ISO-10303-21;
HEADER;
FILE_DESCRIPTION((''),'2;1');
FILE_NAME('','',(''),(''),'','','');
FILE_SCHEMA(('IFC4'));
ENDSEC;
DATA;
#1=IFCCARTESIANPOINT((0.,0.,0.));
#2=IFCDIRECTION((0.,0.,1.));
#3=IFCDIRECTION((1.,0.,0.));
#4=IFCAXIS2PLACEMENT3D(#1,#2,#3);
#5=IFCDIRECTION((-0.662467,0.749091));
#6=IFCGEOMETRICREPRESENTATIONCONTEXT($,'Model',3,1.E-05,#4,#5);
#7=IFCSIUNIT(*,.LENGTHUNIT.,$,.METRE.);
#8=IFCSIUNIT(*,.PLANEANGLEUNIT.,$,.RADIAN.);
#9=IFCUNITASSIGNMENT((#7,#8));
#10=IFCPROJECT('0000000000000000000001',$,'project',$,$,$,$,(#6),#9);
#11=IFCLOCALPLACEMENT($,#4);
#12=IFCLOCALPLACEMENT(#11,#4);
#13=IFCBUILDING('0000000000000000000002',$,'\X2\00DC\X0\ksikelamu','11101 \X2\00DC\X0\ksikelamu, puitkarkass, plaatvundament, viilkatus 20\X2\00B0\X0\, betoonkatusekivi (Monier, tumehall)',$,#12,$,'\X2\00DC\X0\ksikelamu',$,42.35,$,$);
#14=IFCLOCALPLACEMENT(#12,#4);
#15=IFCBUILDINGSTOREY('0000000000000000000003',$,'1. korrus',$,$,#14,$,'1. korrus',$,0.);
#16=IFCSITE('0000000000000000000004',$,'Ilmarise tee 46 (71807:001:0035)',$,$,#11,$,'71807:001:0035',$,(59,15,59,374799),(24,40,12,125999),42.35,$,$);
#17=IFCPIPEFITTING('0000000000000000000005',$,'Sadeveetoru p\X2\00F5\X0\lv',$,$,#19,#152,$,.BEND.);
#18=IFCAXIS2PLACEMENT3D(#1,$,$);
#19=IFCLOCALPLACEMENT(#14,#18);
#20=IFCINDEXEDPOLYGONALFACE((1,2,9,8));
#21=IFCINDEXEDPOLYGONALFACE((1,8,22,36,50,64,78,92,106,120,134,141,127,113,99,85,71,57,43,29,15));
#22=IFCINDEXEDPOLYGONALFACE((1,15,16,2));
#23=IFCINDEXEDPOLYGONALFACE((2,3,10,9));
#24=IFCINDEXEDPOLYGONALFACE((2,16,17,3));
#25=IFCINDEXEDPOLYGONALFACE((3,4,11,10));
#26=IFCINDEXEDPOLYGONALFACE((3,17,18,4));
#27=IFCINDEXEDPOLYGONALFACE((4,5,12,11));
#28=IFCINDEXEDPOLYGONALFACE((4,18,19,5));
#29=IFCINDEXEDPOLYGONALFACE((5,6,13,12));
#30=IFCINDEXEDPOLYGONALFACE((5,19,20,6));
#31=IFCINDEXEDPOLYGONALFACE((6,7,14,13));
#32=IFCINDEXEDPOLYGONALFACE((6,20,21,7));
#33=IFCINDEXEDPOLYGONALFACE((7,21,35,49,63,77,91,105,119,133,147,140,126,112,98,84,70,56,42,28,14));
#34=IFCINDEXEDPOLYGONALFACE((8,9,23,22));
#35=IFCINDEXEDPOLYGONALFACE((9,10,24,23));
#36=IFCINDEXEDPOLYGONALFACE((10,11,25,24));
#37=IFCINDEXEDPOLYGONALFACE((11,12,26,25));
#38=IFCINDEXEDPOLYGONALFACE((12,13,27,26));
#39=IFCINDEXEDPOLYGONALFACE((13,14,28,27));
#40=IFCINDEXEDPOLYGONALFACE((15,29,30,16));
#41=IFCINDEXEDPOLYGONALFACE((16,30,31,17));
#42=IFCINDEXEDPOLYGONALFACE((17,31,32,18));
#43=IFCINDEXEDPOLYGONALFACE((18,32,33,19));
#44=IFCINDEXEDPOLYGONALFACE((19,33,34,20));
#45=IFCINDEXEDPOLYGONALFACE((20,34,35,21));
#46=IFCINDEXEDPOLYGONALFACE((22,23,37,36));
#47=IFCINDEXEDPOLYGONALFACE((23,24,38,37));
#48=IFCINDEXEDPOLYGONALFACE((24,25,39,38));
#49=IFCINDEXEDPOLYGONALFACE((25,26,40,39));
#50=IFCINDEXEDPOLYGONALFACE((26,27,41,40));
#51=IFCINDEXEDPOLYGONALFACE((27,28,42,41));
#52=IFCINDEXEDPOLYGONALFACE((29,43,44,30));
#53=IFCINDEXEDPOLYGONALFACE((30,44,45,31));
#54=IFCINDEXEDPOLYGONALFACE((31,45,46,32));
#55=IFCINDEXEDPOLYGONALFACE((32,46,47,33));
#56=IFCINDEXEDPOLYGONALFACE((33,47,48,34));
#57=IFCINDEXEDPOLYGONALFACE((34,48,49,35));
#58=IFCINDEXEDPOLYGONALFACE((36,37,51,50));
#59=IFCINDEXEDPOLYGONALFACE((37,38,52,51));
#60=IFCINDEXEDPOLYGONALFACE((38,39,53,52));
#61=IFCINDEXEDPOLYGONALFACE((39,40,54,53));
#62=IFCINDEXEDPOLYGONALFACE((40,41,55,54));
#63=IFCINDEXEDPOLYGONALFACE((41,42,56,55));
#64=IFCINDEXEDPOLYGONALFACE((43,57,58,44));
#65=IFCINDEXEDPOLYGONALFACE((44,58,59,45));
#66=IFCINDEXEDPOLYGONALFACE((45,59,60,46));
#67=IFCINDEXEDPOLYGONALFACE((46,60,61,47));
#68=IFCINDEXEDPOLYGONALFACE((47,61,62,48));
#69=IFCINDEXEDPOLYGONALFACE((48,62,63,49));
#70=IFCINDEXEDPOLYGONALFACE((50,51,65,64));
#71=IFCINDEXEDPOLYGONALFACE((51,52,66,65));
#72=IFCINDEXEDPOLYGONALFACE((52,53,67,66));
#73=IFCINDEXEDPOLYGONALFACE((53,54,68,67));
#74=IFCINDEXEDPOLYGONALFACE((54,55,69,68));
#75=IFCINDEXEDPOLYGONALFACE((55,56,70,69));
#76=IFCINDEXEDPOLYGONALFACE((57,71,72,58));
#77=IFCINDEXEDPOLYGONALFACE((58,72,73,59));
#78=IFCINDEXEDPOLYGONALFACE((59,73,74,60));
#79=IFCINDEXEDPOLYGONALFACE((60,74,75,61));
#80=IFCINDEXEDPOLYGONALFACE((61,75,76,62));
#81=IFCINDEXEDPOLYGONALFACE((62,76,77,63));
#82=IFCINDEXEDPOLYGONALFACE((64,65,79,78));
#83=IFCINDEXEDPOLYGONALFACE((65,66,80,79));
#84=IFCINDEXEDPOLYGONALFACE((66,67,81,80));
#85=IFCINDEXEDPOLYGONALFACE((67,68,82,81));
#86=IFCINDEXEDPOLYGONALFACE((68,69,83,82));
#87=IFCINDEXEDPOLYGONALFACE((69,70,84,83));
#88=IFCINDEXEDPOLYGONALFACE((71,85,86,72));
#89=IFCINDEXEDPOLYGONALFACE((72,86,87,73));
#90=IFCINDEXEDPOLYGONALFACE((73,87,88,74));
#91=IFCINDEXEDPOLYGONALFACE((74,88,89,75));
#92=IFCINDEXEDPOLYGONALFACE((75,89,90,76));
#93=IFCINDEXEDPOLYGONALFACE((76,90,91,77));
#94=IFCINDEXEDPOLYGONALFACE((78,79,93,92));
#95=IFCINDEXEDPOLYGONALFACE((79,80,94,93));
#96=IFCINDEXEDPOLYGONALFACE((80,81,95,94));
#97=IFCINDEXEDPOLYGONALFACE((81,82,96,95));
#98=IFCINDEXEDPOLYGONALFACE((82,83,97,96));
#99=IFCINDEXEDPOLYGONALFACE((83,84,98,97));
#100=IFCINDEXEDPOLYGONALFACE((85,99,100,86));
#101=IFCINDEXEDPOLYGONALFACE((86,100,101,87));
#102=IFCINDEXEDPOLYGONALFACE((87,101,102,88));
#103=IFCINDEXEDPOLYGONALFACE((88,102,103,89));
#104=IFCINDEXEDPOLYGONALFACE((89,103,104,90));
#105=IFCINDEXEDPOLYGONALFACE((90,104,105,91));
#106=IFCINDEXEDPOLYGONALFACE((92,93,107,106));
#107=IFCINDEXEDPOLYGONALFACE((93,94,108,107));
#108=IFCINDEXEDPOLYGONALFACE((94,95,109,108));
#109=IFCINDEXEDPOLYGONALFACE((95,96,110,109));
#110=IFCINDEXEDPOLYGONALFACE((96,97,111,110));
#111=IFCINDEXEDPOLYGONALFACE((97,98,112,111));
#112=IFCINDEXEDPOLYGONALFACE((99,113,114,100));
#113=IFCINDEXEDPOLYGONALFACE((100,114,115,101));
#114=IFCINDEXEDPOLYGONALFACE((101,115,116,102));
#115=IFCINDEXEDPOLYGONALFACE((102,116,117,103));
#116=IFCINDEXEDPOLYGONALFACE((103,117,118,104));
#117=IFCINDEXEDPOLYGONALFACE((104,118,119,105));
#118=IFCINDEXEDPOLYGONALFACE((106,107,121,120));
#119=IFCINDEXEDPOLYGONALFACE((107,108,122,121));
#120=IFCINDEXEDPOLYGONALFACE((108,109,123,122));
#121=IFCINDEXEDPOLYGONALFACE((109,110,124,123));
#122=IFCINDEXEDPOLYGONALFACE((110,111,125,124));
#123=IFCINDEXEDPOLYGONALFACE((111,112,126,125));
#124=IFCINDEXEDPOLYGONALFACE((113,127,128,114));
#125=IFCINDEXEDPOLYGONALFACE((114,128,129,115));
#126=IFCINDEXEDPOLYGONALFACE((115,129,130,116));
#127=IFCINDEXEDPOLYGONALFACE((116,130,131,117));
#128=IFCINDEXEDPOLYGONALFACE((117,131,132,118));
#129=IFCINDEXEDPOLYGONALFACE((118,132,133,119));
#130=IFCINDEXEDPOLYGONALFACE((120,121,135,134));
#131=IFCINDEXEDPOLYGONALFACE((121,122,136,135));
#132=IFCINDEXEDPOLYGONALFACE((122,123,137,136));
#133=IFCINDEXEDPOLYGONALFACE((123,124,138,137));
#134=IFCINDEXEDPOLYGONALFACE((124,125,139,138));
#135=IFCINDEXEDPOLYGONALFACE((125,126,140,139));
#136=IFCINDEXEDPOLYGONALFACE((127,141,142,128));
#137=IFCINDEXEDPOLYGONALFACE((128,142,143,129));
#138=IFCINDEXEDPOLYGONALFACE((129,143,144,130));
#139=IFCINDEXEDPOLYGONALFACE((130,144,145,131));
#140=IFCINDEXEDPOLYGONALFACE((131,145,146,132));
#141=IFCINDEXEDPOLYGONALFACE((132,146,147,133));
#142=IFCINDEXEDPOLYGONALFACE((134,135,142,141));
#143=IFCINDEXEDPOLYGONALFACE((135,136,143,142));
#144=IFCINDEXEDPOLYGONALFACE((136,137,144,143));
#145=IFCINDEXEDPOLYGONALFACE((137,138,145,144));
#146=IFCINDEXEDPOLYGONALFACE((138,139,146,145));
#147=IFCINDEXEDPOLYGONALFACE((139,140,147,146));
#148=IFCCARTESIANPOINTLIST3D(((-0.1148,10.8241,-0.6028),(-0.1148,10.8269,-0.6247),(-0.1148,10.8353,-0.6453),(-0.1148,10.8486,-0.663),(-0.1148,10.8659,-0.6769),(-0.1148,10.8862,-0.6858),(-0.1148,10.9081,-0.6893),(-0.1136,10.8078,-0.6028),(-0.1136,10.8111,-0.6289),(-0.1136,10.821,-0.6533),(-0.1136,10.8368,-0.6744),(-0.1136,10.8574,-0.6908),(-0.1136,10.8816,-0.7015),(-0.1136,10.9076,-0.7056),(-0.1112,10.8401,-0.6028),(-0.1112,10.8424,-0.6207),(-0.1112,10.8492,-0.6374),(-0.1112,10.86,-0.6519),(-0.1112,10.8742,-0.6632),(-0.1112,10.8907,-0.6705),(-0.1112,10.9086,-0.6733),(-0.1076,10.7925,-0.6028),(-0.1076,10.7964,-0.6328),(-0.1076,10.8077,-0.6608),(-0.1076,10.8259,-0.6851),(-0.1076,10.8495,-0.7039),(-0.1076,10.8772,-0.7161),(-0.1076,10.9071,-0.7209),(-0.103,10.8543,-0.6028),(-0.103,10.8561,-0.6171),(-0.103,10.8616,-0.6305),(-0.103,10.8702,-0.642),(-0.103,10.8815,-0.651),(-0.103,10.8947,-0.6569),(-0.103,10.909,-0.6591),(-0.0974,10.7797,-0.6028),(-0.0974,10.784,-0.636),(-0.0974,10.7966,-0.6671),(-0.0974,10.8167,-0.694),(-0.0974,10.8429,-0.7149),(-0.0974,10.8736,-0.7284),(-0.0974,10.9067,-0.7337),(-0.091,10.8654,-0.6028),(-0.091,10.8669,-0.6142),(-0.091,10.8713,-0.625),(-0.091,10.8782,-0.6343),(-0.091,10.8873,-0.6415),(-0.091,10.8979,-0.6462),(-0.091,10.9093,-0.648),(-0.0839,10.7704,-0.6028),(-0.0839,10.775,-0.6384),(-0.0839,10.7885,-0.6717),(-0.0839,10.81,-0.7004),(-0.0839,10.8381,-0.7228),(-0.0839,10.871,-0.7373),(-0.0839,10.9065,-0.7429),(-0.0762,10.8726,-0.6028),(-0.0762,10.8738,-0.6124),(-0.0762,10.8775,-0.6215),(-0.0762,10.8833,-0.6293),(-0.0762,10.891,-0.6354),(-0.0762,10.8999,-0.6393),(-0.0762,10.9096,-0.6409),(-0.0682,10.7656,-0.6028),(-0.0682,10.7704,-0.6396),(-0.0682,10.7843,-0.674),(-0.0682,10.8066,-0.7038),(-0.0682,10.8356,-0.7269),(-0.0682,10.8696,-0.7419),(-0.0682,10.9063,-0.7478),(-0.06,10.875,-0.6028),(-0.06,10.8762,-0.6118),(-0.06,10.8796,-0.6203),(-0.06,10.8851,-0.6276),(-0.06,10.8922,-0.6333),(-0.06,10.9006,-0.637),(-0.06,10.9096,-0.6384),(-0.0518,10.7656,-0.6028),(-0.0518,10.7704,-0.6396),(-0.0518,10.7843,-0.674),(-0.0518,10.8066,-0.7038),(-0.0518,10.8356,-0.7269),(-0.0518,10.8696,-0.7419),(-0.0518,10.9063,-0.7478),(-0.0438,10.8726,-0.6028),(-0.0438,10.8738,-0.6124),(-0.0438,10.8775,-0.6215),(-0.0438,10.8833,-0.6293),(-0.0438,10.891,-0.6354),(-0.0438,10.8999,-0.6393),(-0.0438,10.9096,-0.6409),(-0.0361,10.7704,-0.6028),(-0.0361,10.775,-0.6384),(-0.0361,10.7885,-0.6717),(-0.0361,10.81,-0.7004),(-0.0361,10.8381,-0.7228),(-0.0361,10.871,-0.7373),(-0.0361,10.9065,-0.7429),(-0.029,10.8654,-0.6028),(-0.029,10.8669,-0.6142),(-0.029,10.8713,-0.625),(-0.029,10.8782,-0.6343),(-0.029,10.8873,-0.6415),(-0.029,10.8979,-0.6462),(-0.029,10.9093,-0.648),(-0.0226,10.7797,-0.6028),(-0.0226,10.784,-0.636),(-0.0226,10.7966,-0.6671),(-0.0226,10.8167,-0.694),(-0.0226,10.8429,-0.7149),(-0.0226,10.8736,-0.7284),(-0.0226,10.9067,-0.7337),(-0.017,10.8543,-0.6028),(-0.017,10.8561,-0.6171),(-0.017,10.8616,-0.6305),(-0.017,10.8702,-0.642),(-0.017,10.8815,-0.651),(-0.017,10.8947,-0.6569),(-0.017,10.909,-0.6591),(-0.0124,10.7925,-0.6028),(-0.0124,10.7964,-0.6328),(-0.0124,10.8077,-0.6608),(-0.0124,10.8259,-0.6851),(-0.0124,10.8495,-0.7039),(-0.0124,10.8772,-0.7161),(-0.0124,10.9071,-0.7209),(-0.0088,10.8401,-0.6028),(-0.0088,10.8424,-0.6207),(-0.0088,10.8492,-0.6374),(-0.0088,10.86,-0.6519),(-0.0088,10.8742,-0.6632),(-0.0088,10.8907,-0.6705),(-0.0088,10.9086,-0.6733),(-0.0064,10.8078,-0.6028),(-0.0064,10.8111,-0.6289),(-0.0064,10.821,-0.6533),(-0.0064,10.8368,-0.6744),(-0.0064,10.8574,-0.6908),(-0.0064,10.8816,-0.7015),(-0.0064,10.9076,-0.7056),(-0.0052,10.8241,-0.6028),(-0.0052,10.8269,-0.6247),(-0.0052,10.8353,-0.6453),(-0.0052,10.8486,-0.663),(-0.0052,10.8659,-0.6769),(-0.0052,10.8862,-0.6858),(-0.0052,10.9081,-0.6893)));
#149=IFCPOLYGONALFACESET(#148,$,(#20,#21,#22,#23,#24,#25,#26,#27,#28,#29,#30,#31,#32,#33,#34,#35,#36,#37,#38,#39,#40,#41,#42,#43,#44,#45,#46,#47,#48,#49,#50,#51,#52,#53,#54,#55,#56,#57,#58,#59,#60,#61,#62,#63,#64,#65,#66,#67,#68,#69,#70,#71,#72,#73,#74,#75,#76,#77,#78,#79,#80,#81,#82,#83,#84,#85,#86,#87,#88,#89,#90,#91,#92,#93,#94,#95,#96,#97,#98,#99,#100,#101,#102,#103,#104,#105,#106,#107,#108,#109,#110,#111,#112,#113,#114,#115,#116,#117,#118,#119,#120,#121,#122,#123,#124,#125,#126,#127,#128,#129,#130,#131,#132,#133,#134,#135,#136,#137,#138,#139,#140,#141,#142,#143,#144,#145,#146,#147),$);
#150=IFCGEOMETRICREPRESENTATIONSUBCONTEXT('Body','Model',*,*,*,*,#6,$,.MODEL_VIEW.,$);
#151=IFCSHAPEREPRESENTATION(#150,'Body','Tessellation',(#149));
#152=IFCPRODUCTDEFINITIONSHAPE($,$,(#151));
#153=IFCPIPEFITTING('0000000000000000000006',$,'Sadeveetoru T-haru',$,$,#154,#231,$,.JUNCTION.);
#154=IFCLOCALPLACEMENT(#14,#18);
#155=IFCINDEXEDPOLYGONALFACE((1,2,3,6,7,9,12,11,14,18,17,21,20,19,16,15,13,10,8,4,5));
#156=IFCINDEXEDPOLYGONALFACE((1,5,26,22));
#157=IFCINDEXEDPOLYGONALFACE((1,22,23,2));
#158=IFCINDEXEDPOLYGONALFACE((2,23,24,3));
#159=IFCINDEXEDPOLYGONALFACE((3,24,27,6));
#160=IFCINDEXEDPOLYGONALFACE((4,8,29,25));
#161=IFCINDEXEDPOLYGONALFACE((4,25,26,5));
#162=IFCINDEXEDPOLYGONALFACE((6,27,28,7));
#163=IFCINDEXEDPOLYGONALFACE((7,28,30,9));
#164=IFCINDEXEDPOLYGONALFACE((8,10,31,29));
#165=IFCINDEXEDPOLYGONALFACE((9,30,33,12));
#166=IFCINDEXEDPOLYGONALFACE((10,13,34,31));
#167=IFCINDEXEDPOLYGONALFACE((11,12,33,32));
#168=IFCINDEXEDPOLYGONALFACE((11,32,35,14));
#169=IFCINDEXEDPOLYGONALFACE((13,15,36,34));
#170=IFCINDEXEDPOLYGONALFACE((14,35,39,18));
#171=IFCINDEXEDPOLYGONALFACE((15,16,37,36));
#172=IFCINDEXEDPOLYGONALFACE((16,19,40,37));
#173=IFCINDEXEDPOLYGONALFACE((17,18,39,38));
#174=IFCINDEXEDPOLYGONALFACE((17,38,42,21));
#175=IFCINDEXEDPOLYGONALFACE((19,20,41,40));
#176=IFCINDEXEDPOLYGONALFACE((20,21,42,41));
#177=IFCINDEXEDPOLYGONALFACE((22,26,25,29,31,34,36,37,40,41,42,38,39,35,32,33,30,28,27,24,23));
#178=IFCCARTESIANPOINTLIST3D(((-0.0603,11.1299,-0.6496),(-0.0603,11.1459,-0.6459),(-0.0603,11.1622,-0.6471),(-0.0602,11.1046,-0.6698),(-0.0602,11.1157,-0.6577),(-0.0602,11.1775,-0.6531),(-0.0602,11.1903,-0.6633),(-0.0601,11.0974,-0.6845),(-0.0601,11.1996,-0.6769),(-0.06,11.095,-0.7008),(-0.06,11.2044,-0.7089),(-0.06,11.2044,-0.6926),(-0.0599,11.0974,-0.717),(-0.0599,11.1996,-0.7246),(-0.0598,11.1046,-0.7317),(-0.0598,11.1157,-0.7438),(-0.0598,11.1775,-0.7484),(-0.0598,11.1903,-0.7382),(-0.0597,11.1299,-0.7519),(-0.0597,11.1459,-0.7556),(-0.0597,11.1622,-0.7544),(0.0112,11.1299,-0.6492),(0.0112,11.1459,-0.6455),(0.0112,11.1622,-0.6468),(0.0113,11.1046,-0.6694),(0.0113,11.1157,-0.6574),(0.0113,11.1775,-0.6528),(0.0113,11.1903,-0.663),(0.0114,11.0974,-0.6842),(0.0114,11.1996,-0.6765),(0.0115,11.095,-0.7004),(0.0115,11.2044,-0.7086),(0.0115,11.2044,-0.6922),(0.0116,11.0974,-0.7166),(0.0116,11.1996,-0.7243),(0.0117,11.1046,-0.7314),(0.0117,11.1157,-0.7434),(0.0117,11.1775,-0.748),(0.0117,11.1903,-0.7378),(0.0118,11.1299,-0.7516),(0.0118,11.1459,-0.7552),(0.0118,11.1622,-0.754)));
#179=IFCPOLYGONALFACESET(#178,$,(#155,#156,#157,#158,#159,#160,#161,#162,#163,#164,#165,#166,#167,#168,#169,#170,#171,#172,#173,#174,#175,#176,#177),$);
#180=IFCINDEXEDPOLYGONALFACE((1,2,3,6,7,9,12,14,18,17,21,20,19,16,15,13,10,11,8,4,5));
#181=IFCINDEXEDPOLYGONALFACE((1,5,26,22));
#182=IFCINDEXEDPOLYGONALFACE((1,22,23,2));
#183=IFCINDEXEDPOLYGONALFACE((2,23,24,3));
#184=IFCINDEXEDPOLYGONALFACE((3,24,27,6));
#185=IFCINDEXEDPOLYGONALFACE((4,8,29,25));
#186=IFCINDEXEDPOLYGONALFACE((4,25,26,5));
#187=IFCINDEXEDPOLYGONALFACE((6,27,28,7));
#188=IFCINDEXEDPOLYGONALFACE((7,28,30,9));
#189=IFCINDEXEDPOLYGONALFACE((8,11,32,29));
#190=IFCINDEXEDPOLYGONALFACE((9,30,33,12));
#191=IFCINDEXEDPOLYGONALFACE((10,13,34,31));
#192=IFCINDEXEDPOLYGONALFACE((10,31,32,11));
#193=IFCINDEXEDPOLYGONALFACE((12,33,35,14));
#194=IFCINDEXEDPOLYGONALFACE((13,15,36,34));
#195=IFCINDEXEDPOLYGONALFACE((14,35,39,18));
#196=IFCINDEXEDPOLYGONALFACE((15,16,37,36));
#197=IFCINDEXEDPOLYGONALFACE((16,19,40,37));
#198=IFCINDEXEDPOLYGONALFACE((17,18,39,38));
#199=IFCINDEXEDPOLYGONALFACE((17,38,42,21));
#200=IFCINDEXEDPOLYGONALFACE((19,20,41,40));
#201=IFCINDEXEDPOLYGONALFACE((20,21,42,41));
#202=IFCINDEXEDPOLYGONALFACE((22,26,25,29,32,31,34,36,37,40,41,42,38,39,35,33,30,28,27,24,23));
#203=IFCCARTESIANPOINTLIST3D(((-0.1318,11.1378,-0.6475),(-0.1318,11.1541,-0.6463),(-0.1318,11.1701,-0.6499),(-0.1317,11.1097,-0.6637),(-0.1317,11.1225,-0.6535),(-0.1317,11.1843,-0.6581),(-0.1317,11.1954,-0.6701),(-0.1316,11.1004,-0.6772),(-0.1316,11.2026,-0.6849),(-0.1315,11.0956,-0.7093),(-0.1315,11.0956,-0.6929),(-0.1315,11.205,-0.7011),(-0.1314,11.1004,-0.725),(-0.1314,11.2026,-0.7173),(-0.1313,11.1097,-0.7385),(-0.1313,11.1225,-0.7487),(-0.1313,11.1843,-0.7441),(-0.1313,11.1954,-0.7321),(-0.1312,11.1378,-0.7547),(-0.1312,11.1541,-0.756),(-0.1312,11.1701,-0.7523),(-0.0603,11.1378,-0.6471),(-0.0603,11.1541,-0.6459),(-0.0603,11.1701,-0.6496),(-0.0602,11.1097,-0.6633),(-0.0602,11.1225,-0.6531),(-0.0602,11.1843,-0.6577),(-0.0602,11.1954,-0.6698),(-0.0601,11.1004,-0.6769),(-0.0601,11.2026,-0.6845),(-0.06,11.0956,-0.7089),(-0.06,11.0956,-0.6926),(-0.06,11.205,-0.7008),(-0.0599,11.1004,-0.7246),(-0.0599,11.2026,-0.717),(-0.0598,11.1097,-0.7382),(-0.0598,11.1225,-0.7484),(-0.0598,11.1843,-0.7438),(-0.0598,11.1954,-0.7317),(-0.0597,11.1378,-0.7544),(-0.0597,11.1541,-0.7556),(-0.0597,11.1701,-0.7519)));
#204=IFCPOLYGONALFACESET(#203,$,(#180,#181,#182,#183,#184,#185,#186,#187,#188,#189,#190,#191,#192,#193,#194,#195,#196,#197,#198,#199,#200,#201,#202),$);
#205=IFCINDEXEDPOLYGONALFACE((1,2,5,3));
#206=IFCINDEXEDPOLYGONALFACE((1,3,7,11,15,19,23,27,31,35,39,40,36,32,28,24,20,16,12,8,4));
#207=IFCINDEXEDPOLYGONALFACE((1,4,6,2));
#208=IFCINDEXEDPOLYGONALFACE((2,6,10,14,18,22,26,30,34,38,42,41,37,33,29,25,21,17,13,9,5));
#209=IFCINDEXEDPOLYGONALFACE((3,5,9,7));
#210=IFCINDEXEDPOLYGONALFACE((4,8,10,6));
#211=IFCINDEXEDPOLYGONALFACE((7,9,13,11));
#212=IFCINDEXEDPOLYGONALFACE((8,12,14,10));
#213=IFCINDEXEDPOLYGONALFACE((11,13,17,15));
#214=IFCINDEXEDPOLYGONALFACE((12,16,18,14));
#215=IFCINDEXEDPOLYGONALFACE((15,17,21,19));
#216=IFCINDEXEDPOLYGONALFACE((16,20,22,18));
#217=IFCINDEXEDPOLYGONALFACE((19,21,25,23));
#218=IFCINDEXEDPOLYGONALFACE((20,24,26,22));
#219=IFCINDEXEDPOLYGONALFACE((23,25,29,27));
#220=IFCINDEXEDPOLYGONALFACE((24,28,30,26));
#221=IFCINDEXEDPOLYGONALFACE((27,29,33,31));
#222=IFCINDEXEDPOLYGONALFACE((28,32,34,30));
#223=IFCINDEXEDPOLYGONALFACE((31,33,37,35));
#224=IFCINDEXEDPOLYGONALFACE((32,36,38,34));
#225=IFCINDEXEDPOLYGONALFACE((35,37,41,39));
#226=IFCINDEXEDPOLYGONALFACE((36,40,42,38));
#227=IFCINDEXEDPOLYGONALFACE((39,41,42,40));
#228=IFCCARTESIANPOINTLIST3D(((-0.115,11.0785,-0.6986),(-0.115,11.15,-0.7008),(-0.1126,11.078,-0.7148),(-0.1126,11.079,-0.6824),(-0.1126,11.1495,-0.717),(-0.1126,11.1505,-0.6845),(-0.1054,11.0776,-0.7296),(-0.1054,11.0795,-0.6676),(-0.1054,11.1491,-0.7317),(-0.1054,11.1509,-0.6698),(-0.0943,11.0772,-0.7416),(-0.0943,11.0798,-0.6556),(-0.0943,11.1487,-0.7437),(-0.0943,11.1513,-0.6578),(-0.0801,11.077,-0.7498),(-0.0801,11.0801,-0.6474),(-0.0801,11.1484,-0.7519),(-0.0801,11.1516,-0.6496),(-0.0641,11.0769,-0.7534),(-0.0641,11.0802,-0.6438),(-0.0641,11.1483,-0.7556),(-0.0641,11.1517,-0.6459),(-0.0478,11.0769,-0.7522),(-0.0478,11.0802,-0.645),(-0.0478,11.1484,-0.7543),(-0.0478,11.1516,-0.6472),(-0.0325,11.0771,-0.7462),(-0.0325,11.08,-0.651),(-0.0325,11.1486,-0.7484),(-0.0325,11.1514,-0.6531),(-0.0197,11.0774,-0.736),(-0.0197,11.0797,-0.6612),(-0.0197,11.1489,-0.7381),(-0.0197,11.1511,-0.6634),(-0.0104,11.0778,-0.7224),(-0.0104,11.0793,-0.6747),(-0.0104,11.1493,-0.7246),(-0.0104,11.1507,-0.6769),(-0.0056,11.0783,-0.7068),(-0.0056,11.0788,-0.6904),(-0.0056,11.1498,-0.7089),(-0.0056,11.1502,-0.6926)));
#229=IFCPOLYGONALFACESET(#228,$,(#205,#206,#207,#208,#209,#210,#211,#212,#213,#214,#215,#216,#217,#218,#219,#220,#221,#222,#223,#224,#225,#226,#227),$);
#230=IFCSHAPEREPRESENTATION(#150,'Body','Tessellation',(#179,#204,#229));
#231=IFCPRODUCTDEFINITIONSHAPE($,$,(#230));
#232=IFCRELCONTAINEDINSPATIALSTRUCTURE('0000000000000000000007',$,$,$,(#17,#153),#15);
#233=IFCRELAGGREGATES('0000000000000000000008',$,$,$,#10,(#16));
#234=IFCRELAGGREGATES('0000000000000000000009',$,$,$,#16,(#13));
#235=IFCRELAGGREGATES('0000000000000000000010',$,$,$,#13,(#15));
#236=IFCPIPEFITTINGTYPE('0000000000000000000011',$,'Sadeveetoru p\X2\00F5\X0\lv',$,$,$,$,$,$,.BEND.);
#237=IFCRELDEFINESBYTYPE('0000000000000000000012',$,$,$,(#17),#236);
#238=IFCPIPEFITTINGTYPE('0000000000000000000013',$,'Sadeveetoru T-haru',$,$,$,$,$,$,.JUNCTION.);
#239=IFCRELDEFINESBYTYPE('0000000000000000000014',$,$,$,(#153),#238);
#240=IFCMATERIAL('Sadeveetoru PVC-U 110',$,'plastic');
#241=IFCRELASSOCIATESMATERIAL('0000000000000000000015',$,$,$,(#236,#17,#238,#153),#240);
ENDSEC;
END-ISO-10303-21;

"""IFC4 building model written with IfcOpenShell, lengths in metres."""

from ifc_helpers import new_model, entity, si_unit, direction, frame, origin_with_axes, place, context, subcontext, project, spatial, circle, extrude, material, type_object, element, save


model = new_model("IFC4")

# Units and contexts
model_context = context("Model", 3, precision=1e-05, world=origin_with_axes(), true_north=direction((-0.662467, 0.749091)))
body_context = subcontext(model_context, "Body", "Model", "MODEL_VIEW")
ifc_project = project(units=[si_unit("LENGTHUNIT", "METRE"), si_unit("PLANEANGLEUNIT", "RADIAN")], contexts=[model_context])

# Site, building, storey
site_placement = place(None, origin_with_axes())
site = spatial("IfcSite", under=ifc_project, at=site_placement, Name="Ilmarise tee 46 (71807:001:0035)", LongName="71807:001:0035", RefLatitude=(59, 15, 59, 374799), RefLongitude=(24, 40, 12, 125999), RefElevation=42.35)
building_placement = place(site_placement, origin_with_axes())
building = spatial("IfcBuilding", under=site, at=building_placement, Name="Üksikelamu", Description="11101 Üksikelamu, puitkarkass, plaatvundament, viilkatus 20°, betoonkatusekivi (Monier, tumehall)", LongName="Üksikelamu", ElevationOfRefHeight=42.35)
storey_placement = place(building_placement, origin_with_axes())
storey = spatial("IfcBuildingStorey", under=building, at=storey_placement, Name="1. korrus", LongName="1. korrus", Elevation=0.0)

# Pipe fittings
ifc_material_1 = material(Name="Sadeveetoru PVC-U 110", Category="plastic")
pipe_fitting_type_1 = type_object("IfcPipeFittingType", Name="Sadeveetoru põlv", PredefinedType="BEND", material=ifc_material_1)
pipe_fitting_1_placement = place(storey_placement, frame((-0.06, 10.82, -0.6907), z_axis=(0.0, 0.0, 1.0), x_axis=(1.0, 0.0, 0.0)))
element("IfcPipeFitting", 1, at=pipe_fitting_1_placement, inside=storey, type_object=pipe_fitting_type_1, material=ifc_material_1, Name="Sadeveetoru põlv", PredefinedType="BEND", context=body_context, shape_type="SweptSolid", body=[
    entity("IfcRevolvedAreaSolid", entity("IfcCircleProfileDef", "AREA", None, None, 0.055), entity("IfcAxis2Placement3D", entity("IfcCartesianPoint", [0.0, 0.0, 0.088]), entity("IfcDirection", [0.0, 0.0, -1.0]), entity("IfcDirection", [0.0, 1.0, 0.0])), entity("IfcAxis1Placement", entity("IfcCartesianPoint", [0.0907, 0.0, 0.0]), entity("IfcDirection", [0.0, 1.0, 0.0])), 1.540503),
])
pipe_fitting_type_2 = type_object("IfcPipeFittingType", Name="Sadeveetoru T-haru", PredefinedType="JUNCTION", material=ifc_material_1)
pipe_fitting_2_placement = place(storey_placement, frame((-0.06, 11.15, -0.7007), z_axis=(0.0, 0.0, 1.0), x_axis=(1.0, 0.0, 0.0)))
element("IfcPipeFitting", 2, at=pipe_fitting_2_placement, inside=storey, type_object=pipe_fitting_type_2, material=ifc_material_1, Name="Sadeveetoru T-haru", PredefinedType="JUNCTION", context=body_context, shape_type="SweptSolid", body=[
    extrude(circle(Radius=0.055), frame((0.0, 0.0, 0.0), z_axis=(0.999988, 0.0, 0.005), x_axis=(0.0, -1.0, 0.0)), (0.0, 0.0, 1.0), 0.0715),
    extrude(circle(Radius=0.055), frame((0.0, 0.0, 0.0), z_axis=(-0.999988, 0.0, -0.005), x_axis=(0.0, 1.0, 0.0)), (0.0, 0.0, 1.0), 0.0715),
    extrude(circle(Radius=0.055), frame((0.0, 0.0, 0.0), z_axis=(0.0, -0.999541, 0.030289), x_axis=(-1.0, 0.0, 0.0)), (0.0, 0.0, 1.0), 0.0715),
])

save(model, "model.ifc")
